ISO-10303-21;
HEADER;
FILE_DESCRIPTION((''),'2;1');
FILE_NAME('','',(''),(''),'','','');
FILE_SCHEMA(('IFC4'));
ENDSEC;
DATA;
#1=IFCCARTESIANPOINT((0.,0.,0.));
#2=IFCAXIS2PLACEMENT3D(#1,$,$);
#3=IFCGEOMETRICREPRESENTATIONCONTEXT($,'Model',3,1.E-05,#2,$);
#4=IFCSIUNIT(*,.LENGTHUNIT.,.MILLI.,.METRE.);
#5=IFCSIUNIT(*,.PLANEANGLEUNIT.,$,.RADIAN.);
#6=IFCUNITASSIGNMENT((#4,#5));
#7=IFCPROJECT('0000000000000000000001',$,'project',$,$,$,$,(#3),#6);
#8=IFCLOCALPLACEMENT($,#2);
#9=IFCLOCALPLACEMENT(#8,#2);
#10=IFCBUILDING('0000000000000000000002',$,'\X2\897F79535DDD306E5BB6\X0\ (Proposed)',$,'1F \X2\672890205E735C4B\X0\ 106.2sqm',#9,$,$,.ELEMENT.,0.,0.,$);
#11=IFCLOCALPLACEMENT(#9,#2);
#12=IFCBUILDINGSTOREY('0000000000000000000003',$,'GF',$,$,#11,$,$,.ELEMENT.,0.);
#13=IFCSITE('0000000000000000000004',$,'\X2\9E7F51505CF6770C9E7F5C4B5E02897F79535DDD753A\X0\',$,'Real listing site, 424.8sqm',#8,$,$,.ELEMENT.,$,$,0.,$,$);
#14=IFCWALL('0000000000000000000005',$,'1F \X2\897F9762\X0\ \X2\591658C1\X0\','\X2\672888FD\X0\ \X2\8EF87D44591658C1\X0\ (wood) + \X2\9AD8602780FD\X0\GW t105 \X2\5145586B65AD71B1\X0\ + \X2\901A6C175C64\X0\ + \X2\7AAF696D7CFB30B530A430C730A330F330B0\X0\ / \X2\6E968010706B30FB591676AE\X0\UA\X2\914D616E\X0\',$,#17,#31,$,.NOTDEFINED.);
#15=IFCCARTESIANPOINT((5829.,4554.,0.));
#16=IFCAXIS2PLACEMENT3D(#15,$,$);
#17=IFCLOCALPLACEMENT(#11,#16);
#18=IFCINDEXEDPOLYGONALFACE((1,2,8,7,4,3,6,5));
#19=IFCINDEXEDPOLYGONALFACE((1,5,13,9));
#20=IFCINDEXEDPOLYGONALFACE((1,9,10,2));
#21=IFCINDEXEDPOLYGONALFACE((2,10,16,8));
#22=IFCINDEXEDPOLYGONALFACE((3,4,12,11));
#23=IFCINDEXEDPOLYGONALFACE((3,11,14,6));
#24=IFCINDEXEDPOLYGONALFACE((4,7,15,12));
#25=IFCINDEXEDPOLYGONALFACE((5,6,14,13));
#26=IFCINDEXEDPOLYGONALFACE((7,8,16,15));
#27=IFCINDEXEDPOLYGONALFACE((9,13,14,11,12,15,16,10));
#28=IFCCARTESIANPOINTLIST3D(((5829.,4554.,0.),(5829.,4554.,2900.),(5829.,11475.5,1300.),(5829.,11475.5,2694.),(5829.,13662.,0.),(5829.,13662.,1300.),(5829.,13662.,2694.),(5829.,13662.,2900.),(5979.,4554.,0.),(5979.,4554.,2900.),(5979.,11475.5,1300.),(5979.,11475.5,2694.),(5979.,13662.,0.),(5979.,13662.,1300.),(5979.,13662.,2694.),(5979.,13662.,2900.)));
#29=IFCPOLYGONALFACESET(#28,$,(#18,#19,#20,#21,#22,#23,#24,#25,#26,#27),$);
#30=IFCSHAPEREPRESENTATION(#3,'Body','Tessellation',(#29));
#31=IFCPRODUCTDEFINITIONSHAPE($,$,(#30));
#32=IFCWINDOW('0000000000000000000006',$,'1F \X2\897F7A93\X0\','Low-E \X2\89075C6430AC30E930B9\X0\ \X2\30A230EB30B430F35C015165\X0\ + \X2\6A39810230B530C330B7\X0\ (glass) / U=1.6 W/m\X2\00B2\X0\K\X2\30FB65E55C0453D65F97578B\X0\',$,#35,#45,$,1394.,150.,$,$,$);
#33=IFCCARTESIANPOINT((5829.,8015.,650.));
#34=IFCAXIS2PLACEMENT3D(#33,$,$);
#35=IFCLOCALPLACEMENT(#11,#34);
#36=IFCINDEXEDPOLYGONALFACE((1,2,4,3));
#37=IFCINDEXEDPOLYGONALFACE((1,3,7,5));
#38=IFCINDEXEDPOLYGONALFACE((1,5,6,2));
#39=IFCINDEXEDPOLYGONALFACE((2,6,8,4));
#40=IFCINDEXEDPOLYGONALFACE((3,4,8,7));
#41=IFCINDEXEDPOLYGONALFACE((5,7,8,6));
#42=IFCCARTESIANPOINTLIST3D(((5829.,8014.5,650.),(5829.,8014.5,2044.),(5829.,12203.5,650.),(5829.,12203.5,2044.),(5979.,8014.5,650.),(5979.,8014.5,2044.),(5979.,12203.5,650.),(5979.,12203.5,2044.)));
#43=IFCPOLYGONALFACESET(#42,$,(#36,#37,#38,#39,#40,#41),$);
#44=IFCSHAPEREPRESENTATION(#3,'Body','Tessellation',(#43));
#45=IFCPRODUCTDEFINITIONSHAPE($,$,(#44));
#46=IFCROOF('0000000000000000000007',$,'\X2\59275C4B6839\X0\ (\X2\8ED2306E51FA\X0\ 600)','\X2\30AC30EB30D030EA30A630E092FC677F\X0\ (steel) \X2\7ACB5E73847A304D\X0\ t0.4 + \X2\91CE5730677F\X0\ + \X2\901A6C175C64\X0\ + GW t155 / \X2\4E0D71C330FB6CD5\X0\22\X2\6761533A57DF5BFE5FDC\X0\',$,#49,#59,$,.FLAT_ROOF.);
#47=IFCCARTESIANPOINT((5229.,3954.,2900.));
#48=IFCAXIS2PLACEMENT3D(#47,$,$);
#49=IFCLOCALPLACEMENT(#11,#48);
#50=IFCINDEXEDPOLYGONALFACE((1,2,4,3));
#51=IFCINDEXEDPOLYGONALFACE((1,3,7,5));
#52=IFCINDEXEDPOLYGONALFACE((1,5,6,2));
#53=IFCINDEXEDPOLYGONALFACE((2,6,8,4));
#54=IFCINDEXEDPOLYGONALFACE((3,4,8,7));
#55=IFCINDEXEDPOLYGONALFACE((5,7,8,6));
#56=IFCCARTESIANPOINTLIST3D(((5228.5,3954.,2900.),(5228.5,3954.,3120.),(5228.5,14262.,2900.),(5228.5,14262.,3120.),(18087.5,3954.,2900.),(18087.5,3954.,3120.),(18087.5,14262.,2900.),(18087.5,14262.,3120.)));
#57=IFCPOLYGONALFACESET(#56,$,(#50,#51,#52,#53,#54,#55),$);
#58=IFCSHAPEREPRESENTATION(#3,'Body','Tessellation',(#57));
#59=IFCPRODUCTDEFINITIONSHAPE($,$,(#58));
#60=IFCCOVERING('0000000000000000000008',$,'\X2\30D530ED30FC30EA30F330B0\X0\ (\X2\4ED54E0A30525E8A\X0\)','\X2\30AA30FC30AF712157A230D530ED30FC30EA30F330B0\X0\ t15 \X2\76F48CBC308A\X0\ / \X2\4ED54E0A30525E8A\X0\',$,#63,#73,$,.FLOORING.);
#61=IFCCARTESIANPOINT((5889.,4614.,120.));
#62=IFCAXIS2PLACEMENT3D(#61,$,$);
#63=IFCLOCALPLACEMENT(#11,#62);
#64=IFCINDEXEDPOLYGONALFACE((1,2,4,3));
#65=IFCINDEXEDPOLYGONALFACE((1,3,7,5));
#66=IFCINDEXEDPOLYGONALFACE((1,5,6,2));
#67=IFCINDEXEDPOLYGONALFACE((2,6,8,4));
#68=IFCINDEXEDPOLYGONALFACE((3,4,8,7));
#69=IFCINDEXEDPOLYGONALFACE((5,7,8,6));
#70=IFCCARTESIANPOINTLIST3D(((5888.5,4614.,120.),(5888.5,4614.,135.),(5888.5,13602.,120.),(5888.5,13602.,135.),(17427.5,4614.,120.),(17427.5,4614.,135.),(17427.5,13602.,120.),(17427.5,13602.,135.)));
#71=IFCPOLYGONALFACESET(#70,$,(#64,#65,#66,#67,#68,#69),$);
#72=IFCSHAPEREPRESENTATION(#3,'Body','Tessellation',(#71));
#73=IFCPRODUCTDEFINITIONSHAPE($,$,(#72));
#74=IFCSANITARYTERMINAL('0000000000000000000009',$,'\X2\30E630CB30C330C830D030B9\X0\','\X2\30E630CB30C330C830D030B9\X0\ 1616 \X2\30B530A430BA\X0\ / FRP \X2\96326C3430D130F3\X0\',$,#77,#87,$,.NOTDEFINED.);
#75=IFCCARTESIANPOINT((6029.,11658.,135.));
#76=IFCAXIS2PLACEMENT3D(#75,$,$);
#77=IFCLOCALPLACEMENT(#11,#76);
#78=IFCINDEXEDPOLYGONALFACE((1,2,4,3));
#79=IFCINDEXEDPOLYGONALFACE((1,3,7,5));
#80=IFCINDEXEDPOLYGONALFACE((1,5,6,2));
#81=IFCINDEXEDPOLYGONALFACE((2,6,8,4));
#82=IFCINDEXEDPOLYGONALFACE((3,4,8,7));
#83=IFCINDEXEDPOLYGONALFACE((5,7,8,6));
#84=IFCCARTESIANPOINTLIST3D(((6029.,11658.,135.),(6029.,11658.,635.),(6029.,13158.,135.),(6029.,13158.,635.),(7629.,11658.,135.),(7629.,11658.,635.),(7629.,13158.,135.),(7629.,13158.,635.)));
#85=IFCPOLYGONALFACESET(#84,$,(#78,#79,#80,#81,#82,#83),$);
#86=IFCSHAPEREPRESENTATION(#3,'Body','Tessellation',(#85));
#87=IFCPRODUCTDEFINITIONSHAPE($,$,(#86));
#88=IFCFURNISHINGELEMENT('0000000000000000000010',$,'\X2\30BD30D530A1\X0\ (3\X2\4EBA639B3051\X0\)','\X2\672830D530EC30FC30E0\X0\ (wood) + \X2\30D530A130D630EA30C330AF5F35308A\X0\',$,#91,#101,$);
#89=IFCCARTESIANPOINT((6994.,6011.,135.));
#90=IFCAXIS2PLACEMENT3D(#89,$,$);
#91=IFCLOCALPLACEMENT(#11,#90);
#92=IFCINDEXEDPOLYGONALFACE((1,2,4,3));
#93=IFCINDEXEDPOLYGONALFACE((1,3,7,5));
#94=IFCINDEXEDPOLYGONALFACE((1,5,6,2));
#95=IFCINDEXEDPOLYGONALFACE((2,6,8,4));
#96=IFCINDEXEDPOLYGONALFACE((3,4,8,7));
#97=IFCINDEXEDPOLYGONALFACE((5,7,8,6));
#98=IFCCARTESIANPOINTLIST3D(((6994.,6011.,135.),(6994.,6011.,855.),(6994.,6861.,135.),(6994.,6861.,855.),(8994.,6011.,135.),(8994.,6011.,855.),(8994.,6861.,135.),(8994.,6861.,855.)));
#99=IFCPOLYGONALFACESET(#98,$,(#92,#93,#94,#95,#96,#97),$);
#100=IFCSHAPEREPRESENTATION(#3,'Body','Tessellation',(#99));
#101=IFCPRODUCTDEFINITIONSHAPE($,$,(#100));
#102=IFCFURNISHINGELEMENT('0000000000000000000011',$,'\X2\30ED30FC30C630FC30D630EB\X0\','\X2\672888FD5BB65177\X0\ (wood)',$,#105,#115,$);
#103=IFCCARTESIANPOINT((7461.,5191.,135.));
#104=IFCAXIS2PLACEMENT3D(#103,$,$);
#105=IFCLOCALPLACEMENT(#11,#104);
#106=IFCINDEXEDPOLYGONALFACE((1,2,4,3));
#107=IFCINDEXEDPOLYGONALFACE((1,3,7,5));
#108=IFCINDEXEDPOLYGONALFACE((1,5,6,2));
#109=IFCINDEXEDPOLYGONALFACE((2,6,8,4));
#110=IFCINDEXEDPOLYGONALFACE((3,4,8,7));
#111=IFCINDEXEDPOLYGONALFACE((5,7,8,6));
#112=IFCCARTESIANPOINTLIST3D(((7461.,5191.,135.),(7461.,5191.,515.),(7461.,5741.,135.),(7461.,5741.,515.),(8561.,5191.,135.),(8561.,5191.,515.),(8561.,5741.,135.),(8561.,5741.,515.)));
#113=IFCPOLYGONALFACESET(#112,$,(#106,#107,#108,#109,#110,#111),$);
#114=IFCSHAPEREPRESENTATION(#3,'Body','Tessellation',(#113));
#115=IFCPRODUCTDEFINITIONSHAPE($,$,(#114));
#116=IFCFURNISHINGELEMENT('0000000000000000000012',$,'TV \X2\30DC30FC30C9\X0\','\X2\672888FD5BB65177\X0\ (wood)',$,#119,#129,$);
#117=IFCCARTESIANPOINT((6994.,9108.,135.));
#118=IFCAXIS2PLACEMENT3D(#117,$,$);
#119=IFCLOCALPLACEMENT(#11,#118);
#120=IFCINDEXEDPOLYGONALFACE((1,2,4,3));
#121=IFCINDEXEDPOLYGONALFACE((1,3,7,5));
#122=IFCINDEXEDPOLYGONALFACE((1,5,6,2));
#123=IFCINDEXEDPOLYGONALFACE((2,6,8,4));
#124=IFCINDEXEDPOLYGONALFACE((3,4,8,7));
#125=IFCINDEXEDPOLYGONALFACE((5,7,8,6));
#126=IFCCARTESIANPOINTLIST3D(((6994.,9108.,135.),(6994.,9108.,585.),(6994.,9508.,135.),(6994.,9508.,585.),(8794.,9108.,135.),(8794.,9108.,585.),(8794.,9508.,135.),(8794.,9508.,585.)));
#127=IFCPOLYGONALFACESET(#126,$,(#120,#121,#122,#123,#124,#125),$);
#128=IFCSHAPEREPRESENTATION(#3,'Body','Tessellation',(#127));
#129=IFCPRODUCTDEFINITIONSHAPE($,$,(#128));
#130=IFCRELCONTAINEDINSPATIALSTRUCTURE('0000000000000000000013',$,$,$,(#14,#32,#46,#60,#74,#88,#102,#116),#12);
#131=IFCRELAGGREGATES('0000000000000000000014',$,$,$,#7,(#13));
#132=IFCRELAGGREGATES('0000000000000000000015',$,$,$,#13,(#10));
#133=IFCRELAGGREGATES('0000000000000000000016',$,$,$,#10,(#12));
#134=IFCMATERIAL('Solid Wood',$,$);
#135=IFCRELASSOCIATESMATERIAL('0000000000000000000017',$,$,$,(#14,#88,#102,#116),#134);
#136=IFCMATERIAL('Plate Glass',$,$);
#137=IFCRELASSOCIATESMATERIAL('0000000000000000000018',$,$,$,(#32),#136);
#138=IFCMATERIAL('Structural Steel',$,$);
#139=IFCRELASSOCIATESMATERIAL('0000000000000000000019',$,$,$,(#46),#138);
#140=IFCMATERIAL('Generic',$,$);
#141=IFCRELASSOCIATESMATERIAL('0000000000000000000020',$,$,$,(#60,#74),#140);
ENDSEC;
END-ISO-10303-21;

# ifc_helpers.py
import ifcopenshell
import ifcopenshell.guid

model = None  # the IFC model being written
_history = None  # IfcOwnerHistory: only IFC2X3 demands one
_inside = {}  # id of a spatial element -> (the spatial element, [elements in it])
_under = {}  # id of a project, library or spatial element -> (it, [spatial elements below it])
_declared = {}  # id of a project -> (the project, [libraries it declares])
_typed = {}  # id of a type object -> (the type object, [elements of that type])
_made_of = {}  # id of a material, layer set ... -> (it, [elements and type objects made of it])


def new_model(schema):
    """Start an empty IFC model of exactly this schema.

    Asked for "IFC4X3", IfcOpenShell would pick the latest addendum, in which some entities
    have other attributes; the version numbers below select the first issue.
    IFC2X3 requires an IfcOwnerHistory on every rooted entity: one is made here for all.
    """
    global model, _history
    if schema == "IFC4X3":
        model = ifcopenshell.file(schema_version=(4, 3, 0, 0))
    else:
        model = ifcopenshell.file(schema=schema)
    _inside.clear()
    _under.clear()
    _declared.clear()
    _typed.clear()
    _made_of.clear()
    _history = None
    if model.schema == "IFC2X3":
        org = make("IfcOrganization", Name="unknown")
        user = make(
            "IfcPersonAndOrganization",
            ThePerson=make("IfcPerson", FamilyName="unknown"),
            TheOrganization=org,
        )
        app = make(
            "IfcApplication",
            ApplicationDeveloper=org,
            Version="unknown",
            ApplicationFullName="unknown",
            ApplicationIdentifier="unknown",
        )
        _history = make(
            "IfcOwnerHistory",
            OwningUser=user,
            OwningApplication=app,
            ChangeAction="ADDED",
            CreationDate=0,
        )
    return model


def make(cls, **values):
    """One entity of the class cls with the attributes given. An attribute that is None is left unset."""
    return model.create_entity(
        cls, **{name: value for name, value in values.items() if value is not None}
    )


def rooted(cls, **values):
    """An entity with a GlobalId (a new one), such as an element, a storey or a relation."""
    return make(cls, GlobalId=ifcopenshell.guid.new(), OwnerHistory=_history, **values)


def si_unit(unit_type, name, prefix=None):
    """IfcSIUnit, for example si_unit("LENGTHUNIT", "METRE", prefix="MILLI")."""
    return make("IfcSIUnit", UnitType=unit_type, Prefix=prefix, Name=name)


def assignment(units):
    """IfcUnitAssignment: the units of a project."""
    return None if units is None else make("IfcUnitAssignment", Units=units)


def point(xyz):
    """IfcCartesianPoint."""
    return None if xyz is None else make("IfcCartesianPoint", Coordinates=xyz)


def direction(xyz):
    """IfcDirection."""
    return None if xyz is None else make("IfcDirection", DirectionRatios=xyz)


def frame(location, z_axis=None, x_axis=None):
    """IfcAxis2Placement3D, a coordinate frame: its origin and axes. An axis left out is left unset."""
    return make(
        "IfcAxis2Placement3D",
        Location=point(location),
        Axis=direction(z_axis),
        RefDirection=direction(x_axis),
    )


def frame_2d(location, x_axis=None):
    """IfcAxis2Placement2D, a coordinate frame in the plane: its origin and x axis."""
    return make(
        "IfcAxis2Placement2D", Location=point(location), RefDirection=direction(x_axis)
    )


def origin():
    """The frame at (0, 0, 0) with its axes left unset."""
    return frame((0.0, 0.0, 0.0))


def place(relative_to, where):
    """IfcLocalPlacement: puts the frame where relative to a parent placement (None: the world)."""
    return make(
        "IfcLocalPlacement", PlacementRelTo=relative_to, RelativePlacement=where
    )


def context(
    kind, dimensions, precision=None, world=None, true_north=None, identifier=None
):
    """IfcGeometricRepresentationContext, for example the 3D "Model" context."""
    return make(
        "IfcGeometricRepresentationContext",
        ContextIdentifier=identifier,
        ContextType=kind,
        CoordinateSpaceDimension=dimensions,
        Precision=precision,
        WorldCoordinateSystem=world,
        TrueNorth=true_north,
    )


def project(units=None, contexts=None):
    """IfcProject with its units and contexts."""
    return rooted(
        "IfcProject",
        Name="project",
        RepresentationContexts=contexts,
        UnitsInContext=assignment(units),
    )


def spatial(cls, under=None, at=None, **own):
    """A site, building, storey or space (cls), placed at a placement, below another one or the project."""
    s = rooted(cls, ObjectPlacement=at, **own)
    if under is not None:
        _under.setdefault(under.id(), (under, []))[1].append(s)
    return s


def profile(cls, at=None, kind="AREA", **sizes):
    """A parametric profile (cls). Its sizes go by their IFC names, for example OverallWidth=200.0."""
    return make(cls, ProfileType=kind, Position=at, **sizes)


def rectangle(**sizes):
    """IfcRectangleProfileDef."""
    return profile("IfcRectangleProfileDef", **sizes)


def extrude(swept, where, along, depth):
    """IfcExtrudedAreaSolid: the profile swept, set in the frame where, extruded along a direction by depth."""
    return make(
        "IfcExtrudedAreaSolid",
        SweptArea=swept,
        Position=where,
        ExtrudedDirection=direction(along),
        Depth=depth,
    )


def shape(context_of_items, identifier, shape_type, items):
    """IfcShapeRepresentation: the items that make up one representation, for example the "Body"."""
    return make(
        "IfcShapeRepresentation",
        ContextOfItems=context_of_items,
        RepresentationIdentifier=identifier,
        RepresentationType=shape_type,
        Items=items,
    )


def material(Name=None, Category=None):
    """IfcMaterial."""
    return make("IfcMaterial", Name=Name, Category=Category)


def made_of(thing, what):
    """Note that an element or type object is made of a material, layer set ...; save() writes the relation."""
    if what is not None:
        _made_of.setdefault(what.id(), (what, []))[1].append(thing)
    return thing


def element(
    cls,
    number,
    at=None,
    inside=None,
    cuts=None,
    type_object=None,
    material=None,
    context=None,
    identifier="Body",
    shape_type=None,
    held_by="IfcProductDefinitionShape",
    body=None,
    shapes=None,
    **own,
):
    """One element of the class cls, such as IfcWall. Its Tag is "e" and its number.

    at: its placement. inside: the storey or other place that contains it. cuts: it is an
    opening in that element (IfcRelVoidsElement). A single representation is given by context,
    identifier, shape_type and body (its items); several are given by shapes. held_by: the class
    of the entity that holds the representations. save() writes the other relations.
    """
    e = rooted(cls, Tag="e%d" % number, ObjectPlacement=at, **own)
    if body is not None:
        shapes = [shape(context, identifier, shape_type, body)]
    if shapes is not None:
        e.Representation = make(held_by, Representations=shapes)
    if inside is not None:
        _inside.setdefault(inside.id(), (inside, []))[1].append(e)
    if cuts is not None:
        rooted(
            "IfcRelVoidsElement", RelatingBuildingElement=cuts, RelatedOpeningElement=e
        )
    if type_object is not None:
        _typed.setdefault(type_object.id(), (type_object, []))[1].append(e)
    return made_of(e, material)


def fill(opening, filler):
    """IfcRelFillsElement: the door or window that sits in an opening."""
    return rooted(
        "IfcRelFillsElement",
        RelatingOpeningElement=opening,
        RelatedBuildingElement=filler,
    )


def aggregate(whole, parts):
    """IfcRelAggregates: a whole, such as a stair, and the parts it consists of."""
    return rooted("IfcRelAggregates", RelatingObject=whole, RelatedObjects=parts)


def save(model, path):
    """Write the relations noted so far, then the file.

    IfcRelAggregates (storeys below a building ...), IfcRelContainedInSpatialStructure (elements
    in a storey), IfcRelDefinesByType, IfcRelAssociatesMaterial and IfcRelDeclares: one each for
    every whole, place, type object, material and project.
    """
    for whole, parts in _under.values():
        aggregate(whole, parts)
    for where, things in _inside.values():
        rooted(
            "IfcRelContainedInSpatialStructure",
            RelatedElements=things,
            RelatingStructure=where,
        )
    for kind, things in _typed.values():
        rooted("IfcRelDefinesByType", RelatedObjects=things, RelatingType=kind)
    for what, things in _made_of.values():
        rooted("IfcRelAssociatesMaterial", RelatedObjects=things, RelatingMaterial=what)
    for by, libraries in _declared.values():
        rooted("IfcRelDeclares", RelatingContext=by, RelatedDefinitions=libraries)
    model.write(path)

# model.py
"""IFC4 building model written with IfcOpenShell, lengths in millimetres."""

from ifc_helpers import new_model, si_unit, frame, frame_2d, origin, place, context, project, spatial, rectangle, extrude, material, element, fill, save


model = new_model("IFC4")

# Units and contexts
model_context = context("Model", 3, precision=1e-05, world=origin())
ifc_project = project(units=[si_unit("LENGTHUNIT", "METRE", prefix="MILLI"), si_unit("PLANEANGLEUNIT", "RADIAN")], contexts=[model_context])

# Site, building, storey
site_placement = place(None, origin())
site = spatial("IfcSite", under=ifc_project, at=site_placement, Name="鹿児島県鹿屋市西祓川町", ObjectType="Real listing site, 424.8sqm", CompositionType="ELEMENT", RefElevation=0.0)
building_placement = place(site_placement, origin())
building = spatial("IfcBuilding", under=site, at=building_placement, Name="西祓川の家 (Proposed)", ObjectType="1F 木造平屋 106.2sqm", CompositionType="ELEMENT", ElevationOfRefHeight=0.0, ElevationOfTerrain=0.0)
storey_placement = place(building_placement, origin())
storey = spatial("IfcBuildingStorey", under=building, at=storey_placement, Name="GF", CompositionType="ELEMENT", Elevation=0.0)

# Shared definitions
ifc_material_1 = material(Name="Solid Wood")

# Shared definitions
ifc_material_2 = material(Name="Plate Glass")

# Wall, opening, window
wall_1_placement = place(storey_placement, frame((5829.0, 4554.0, 0.0)))
wall_1 = element("IfcWall", 1, at=wall_1_placement, inside=storey, material=ifc_material_1, Name="1F 西面 外壁", Description="木製 軸組外壁 (wood) + 高性能GW t105 充填断熱 + 通気層 + 窯業系サイディング / 準耐火・外皮UA配慮", PredefinedType="NOTDEFINED", context=model_context, shape_type="SweptSolid", body=[
    extrude(rectangle(XDim=150.0, YDim=9108.0, at=frame_2d((75.0, 4554.0))), frame((5829.0, 4554.0, 0.0)), (0.0, 0.0, 1.0), 2900.0),
])
opening_1_placement = place(storey_placement, frame((5829.0, 8015.0, 650.0)))
opening_1 = element("IfcOpeningElement", 2, at=opening_1_placement, cuts=wall_1, PredefinedType="NOTDEFINED", context=model_context, shape_type="SweptSolid", body=[
    extrude(rectangle(XDim=150.0, YDim=4189.0, at=frame_2d((75.0, 2094.0))), frame((5829.0, 8015.0, 650.0)), (0.0, 0.0, 1.0), 1394.0),
])
window_1_placement = place(storey_placement, frame((5829.0, 8015.0, 650.0)))
window_1 = element("IfcWindow", 3, at=window_1_placement, inside=storey, material=ifc_material_2, Name="1F 西窓", Description="Low-E 複層ガラス アルゴン封入 + 樹脂サッシ (glass) / U=1.6 W/m²K・日射取得型", OverallHeight=1394.0, OverallWidth=150.0, context=model_context, shape_type="SweptSolid", body=[
    extrude(rectangle(XDim=150.0, YDim=4189.0, at=frame_2d((75.0, 2094.0))), frame((5829.0, 8015.0, 650.0)), (0.0, 0.0, 1.0), 1394.0),
])
fill(opening_1, window_1)

# Roof
ifc_material_3 = material(Name="Structural Steel")
roof_placement = place(storey_placement, frame((5229.0, 3954.0, 2900.0)))
element("IfcRoof", 4, at=roof_placement, inside=storey, material=ifc_material_3, Name="大屋根 (軒の出 600)", Description="ガルバリウム鋼板 (steel) 立平葺き t0.4 + 野地板 + 通気層 + GW t155 / 不燃・法22条区域対応", PredefinedType="FLAT_ROOF", context=model_context, shape_type="SweptSolid", body=[
    extrude(rectangle(XDim=12859.0, YDim=10308.0, at=frame_2d((6429.0, 5154.0))), frame((5229.0, 3954.0, 2900.0)), (0.0, 0.0, 1.0), 220.0),
])

# Covering
ifc_material_4 = material(Name="Generic")
covering_placement = place(storey_placement, frame((5889.0, 4614.0, 120.0)))
element("IfcCovering", 5, at=covering_placement, inside=storey, material=ifc_material_4, Name="フローリング (仕上げ床)", Description="オーク無垢フローリング t15 直貼り / 仕上げ床", PredefinedType="FLOORING", context=model_context, shape_type="SweptSolid", body=[
    extrude(rectangle(XDim=11539.0, YDim=8988.0, at=frame_2d((5769.0, 4494.0))), frame((5889.0, 4614.0, 120.0)), (0.0, 0.0, 1.0), 15.0),
])

# Sanitary terminal
sanitary_terminal_placement = place(storey_placement, frame((6029.0, 11658.0, 135.0)))
element("IfcSanitaryTerminal", 6, at=sanitary_terminal_placement, inside=storey, material=ifc_material_4, Name="ユニットバス", Description="ユニットバス 1616 サイズ / FRP 防水パン", PredefinedType="NOTDEFINED", context=model_context, shape_type="SweptSolid", body=[
    extrude(rectangle(XDim=1600.0, YDim=1500.0, at=frame_2d((800.0, 750.0))), frame((6029.0, 11658.0, 135.0)), (0.0, 0.0, 1.0), 500.0),
])

# Furnishing elements
furnishing_1_placement = place(storey_placement, frame((6994.0, 6011.0, 135.0)))
element("IfcFurnishingElement", 7, at=furnishing_1_placement, inside=storey, material=ifc_material_1, Name="ソファ (3人掛け)", Description="木フレーム (wood) + ファブリック張り", context=model_context, shape_type="SweptSolid", body=[
    extrude(rectangle(XDim=2000.0, YDim=850.0, at=frame_2d((1000.0, 425.0))), frame((6994.0, 6011.0, 135.0)), (0.0, 0.0, 1.0), 720.0),
])
furnishing_2_placement = place(storey_placement, frame((7461.0, 5191.0, 135.0)))
element("IfcFurnishingElement", 8, at=furnishing_2_placement, inside=storey, material=ifc_material_1, Name="ローテーブル", Description="木製家具 (wood)", context=model_context, shape_type="SweptSolid", body=[
    extrude(rectangle(XDim=1100.0, YDim=550.0, at=frame_2d((550.0, 275.0))), frame((7461.0, 5191.0, 135.0)), (0.0, 0.0, 1.0), 380.0),
])
furnishing_3_placement = place(storey_placement, frame((6994.0, 9108.0, 135.0)))
element("IfcFurnishingElement", 9, at=furnishing_3_placement, inside=storey, material=ifc_material_1, Name="TV ボード", Description="木製家具 (wood)", context=model_context, shape_type="SweptSolid", body=[
    extrude(rectangle(XDim=1800.0, YDim=400.0, at=frame_2d((900.0, 200.0))), frame((6994.0, 9108.0, 135.0)), (0.0, 0.0, 1.0), 450.0),
])

save(model, "model.ifc")
